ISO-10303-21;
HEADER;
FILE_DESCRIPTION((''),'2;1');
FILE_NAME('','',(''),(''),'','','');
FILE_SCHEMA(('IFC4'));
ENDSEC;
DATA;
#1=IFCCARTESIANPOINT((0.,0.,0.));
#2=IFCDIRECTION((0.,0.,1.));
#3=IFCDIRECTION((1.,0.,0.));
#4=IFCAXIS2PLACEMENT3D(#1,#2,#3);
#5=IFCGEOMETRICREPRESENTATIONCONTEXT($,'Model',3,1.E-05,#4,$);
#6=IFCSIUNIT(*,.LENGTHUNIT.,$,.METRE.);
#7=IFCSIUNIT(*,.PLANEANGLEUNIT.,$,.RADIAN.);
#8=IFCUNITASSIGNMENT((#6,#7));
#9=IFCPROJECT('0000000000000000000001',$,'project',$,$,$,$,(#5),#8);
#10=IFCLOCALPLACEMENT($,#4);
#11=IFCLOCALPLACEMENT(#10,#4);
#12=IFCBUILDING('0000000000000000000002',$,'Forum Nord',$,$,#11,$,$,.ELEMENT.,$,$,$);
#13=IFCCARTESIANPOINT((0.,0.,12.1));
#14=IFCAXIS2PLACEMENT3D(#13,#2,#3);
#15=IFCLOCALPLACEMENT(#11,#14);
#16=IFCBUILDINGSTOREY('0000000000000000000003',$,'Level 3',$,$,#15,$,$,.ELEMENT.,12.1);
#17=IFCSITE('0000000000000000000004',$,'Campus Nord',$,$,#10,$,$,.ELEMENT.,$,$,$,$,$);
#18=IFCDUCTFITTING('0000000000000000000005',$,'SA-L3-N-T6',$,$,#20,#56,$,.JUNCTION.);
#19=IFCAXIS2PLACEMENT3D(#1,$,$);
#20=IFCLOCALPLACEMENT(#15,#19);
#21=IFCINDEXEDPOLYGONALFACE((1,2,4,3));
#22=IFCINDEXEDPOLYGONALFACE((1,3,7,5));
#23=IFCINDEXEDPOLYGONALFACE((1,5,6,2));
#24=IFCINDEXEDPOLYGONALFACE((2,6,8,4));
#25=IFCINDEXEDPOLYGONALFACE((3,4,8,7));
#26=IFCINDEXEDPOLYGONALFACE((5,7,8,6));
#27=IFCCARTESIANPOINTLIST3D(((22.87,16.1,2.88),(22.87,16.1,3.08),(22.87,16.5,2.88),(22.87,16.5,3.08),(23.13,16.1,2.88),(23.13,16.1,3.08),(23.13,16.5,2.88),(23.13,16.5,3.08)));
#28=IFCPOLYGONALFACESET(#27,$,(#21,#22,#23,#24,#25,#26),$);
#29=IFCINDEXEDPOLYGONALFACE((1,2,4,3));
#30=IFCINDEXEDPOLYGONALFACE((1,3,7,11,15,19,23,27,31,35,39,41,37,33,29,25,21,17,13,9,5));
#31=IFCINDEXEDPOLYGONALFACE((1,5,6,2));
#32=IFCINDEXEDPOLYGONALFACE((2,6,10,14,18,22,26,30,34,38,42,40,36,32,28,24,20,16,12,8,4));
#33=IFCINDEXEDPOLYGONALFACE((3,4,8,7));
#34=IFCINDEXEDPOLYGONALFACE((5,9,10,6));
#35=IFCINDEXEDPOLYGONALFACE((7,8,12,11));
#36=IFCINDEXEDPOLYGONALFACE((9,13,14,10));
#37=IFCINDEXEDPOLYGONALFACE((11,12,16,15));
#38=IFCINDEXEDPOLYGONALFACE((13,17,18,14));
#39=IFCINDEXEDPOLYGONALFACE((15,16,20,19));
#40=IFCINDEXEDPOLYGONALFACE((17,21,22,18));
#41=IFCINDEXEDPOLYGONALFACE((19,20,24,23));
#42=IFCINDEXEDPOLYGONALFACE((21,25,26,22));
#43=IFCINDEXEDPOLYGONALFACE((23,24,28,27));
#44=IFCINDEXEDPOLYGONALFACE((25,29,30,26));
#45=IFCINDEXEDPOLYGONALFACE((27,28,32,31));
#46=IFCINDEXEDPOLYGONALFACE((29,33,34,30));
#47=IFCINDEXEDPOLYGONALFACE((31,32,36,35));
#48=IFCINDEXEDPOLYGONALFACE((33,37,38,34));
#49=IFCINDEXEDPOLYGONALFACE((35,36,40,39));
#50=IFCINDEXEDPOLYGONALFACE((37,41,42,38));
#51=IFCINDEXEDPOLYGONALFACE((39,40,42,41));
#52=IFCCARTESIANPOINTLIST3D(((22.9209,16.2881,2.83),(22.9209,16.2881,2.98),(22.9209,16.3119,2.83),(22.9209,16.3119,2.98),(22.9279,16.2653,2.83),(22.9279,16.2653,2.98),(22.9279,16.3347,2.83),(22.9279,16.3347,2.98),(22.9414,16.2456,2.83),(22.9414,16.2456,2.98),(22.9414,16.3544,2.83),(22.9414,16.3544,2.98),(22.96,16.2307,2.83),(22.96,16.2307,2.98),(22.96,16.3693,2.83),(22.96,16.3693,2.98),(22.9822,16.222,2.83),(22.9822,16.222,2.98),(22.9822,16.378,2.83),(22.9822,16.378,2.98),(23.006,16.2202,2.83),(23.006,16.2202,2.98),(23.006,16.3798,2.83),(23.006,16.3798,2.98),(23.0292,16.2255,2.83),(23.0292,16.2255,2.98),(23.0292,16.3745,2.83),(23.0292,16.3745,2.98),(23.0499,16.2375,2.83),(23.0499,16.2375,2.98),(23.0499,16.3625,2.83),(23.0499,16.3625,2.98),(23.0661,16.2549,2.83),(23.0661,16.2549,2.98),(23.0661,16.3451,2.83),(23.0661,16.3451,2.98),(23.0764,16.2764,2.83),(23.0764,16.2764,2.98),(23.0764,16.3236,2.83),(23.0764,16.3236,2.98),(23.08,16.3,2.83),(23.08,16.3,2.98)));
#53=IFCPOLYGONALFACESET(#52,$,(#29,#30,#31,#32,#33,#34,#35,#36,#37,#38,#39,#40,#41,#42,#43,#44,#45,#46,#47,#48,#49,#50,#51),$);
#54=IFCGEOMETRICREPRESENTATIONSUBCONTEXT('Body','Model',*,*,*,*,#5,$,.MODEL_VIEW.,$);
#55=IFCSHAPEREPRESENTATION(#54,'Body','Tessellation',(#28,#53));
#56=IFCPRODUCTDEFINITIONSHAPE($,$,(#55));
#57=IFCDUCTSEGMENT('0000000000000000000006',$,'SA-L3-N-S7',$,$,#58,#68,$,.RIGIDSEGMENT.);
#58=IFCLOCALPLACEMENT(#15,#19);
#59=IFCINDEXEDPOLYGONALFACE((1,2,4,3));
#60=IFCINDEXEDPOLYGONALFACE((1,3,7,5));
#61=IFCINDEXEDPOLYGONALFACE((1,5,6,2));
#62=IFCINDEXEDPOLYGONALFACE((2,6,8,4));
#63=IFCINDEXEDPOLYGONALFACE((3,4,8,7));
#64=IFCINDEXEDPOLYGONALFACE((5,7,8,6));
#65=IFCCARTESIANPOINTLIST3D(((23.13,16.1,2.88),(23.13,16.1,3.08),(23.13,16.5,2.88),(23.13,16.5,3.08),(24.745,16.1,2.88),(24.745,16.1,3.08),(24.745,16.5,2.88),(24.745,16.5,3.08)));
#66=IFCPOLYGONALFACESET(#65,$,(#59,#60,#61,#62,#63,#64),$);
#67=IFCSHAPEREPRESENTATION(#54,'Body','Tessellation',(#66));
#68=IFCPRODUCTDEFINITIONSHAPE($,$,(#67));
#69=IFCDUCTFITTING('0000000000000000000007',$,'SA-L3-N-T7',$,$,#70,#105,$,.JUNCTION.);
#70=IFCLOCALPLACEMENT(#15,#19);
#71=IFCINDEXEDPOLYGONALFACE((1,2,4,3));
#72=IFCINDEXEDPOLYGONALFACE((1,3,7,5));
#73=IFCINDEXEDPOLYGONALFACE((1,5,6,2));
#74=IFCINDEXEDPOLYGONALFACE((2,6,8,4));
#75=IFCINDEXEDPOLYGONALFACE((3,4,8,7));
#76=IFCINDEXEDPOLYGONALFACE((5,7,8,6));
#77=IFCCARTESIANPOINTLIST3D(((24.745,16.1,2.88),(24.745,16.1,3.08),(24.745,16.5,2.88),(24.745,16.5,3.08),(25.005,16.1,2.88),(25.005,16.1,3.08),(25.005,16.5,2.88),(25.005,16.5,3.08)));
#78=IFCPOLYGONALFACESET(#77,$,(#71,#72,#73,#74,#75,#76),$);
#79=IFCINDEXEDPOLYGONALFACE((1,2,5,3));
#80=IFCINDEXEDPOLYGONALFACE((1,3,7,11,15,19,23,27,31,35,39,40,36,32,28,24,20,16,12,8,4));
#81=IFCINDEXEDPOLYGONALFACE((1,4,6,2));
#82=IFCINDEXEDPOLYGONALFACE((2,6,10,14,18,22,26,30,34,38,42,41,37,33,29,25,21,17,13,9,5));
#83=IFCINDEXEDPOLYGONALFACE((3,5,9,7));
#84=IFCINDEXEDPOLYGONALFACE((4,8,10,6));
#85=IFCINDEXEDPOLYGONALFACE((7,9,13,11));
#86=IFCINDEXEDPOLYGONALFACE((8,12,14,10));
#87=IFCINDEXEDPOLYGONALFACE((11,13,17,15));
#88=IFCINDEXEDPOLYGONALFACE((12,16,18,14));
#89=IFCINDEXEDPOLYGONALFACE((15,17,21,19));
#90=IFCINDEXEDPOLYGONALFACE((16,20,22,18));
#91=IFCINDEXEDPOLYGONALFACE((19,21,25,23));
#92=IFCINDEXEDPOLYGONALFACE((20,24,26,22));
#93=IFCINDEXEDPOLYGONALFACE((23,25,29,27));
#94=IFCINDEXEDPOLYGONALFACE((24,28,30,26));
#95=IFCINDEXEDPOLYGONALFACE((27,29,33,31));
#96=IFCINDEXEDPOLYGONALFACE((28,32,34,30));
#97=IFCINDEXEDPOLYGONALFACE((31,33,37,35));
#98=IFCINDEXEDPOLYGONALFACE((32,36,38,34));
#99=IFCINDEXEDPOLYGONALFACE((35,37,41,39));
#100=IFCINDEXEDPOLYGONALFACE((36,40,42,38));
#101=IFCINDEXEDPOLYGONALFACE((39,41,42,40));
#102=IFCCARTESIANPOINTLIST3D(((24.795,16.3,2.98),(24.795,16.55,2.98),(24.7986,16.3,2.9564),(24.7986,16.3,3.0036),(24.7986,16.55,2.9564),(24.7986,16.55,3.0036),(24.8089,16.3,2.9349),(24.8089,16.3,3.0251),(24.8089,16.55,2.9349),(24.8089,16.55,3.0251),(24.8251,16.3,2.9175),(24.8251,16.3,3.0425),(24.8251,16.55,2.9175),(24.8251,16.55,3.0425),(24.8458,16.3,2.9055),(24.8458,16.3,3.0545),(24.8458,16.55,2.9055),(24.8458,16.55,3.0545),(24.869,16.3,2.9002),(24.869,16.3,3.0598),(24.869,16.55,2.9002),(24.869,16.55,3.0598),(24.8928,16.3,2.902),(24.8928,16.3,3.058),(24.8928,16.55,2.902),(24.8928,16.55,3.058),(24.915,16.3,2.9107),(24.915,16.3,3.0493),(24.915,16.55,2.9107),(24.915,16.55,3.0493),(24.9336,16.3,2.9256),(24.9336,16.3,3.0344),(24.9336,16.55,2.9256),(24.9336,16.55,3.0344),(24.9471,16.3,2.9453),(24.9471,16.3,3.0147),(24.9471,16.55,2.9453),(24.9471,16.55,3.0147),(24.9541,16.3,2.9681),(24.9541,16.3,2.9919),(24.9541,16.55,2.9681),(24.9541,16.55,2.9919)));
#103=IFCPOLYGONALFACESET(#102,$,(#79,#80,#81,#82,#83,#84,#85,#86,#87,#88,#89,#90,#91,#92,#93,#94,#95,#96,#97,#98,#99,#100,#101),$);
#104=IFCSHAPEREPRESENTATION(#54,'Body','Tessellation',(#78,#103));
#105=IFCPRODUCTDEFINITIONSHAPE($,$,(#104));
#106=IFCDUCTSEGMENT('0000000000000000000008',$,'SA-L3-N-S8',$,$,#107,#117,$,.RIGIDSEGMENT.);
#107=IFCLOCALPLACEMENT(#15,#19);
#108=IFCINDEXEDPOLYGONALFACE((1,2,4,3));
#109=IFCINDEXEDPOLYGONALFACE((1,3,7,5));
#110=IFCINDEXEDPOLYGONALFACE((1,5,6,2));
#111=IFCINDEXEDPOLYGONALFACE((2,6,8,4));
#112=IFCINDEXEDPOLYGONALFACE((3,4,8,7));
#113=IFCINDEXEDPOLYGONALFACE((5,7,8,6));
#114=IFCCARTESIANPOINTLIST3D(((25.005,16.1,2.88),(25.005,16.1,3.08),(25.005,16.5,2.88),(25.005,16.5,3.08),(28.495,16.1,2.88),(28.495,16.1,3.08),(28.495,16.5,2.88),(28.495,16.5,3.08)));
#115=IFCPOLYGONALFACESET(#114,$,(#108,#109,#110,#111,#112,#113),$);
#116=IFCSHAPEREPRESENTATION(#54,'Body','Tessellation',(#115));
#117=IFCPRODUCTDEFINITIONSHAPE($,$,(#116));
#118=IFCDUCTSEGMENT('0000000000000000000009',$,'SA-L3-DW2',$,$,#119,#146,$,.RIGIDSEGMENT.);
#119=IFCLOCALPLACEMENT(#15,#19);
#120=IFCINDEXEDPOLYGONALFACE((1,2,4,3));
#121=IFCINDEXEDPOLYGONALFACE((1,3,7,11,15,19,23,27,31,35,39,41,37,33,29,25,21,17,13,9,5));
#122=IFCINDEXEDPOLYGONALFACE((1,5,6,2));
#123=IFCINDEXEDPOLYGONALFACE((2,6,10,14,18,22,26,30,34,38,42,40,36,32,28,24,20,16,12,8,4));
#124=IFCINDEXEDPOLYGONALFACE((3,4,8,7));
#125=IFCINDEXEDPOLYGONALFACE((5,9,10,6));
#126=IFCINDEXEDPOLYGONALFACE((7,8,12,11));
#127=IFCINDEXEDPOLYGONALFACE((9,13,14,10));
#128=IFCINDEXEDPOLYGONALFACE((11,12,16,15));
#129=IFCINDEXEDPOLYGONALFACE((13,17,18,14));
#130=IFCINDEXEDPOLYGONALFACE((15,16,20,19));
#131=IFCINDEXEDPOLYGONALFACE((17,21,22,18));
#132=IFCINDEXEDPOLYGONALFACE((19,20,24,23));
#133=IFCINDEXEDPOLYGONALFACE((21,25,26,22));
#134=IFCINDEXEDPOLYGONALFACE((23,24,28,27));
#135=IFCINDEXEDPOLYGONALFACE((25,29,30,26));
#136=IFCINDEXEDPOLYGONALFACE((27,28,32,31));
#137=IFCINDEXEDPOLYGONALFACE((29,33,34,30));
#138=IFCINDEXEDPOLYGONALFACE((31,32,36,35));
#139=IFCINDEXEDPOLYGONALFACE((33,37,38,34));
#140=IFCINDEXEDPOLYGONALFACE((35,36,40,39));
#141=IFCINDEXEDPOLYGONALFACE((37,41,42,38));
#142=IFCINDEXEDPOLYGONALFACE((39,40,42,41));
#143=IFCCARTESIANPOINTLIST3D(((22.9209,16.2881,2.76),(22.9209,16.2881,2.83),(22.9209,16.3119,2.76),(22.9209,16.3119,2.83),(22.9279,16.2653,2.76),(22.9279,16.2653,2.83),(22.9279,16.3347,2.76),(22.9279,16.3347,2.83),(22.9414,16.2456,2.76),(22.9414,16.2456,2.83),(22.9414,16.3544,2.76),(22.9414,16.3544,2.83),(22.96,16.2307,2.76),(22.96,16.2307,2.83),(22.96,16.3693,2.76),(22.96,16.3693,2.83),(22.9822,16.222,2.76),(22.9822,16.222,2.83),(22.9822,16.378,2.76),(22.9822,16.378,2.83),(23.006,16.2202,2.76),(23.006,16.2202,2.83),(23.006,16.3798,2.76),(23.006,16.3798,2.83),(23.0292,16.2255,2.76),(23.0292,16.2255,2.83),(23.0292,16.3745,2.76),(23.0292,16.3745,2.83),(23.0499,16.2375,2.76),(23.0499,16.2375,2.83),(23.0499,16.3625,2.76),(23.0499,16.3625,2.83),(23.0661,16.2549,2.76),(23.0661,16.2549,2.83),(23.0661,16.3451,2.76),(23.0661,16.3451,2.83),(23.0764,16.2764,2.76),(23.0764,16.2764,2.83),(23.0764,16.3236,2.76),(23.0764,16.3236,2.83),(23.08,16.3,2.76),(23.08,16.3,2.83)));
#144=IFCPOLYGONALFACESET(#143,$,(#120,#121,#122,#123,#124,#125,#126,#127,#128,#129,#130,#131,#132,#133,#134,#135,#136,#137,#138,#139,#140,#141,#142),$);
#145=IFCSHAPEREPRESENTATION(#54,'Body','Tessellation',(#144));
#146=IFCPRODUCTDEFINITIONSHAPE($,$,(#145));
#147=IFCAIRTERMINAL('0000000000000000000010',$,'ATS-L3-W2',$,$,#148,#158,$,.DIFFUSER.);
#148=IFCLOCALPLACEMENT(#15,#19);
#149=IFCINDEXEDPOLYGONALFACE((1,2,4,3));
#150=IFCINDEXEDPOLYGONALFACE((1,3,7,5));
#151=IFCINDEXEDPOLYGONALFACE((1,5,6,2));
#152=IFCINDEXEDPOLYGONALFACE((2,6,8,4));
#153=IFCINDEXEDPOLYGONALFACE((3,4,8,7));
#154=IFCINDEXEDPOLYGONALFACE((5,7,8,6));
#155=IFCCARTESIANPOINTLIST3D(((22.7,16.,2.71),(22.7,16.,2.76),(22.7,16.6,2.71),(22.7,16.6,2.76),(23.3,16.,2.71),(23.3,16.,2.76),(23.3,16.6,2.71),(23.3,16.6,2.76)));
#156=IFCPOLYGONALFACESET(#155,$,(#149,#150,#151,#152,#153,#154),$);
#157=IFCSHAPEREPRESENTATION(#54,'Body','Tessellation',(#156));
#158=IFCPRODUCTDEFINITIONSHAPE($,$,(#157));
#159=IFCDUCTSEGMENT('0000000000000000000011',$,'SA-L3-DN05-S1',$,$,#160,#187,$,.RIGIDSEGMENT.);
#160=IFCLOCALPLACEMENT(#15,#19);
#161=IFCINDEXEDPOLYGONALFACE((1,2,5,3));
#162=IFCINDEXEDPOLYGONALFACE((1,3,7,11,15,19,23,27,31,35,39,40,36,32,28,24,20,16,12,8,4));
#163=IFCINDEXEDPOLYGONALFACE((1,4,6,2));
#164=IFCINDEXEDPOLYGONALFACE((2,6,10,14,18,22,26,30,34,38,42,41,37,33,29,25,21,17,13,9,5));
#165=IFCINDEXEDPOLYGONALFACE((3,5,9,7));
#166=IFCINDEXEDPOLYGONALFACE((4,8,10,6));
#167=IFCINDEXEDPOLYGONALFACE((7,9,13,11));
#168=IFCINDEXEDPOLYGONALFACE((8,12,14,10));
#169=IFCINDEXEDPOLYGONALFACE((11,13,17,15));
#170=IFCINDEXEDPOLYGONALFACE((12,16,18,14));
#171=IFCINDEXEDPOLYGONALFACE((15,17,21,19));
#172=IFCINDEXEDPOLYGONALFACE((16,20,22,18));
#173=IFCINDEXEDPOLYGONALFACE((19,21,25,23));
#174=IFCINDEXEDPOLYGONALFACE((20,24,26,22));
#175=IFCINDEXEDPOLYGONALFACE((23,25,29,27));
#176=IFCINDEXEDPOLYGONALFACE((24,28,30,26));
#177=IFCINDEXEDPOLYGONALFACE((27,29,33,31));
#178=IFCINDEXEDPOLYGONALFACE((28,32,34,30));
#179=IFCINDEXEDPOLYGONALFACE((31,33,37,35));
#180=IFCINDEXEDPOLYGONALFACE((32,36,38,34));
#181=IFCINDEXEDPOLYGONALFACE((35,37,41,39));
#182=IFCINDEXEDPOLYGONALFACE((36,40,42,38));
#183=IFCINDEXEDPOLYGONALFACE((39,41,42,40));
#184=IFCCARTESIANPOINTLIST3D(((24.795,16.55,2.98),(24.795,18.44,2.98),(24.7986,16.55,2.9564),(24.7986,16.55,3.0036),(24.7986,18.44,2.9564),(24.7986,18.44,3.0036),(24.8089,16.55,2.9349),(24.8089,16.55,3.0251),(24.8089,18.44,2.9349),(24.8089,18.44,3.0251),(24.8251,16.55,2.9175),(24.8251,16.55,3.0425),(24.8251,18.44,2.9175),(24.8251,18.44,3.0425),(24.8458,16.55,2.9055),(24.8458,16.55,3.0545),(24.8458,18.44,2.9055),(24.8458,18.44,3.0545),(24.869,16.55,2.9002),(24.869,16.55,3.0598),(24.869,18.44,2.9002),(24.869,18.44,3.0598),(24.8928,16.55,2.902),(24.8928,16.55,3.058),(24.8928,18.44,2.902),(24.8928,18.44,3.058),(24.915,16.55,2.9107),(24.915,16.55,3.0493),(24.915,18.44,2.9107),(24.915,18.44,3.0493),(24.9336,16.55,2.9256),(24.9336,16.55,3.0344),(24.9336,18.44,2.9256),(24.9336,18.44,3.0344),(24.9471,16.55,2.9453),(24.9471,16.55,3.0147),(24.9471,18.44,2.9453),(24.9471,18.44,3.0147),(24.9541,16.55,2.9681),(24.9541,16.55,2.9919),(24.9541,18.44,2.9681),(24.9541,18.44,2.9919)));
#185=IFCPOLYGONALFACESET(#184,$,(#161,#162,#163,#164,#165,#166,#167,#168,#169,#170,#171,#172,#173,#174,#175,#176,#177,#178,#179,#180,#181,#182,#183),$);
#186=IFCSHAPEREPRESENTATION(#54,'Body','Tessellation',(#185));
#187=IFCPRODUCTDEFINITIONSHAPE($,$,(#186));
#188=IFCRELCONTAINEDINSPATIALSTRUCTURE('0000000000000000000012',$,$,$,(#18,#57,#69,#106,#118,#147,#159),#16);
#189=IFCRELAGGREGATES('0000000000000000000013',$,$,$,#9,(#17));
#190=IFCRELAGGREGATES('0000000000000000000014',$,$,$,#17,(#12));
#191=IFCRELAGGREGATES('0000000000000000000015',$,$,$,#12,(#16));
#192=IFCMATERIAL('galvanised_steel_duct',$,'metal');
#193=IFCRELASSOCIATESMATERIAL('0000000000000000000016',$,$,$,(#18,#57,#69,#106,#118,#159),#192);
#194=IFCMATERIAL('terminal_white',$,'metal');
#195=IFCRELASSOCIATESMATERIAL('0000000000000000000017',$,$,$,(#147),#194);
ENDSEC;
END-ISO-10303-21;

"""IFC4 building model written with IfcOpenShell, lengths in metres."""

from ifc_helpers import new_model, si_unit, frame, origin_with_axes, origin_2d_with_axis, place, context, subcontext, project, spatial, rectangle, circle, extrude, material, element, save


model = new_model("IFC4")

# Units and contexts
model_context = context("Model", 3, precision=1e-05, world=origin_with_axes())
body_context = subcontext(model_context, "Body", "Model", "MODEL_VIEW")
ifc_project = project(units=[si_unit("LENGTHUNIT", "METRE"), si_unit("PLANEANGLEUNIT", "RADIAN")], contexts=[model_context])

# Site, building, storey
site_placement = place(None, origin_with_axes())
site = spatial("IfcSite", under=ifc_project, at=site_placement, Name="Campus Nord", CompositionType="ELEMENT")
building_placement = place(site_placement, origin_with_axes())
building = spatial("IfcBuilding", under=site, at=building_placement, Name="Forum Nord", CompositionType="ELEMENT")
storey_placement = place(building_placement, frame((0.0, 0.0, 12.1), z_axis=(0.0, 0.0, 1.0), x_axis=(1.0, 0.0, 0.0)))
storey = spatial("IfcBuildingStorey", under=building, at=storey_placement, Name="Level 3", CompositionType="ELEMENT", Elevation=12.1)

# Duct fitting
ifc_material_1 = material(Name="galvanised_steel_duct", Category="metal")
duct_fitting_1_placement = place(storey_placement, frame((22.87, 16.3, 2.98), z_axis=(1.0, 0.0, 0.0), x_axis=(0.0, 1.0, 0.0)))
element("IfcDuctFitting", 1, at=duct_fitting_1_placement, inside=storey, material=ifc_material_1, Name="SA-L3-N-T6", PredefinedType="JUNCTION", context=body_context, shape_type="SweptSolid", body=[
    extrude(rectangle(XDim=0.4, YDim=0.2, at=origin_2d_with_axis()), origin_with_axes(), (0.0, 0.0, 1.0), 0.26),
    extrude(circle(Radius=0.08, at=origin_2d_with_axis()), frame((0.0, 0.0, 0.13), z_axis=(0.0, -1.0, 0.0), x_axis=(0.0, 0.0, 1.0)), (0.0, 0.0, 1.0), 0.15),
])

# Duct segment
duct_segment_1_placement = place(storey_placement, frame((23.13, 16.3, 2.98), z_axis=(1.0, 0.0, 0.0), x_axis=(0.0, 1.0, 0.0)))
element("IfcDuctSegment", 2, at=duct_segment_1_placement, inside=storey, material=ifc_material_1, Name="SA-L3-N-S7", PredefinedType="RIGIDSEGMENT", context=body_context, shape_type="SweptSolid", body=[
    extrude(rectangle(XDim=0.4, YDim=0.2, at=origin_2d_with_axis()), origin_with_axes(), (0.0, 0.0, 1.0), 1.615),
])

# Duct fitting
duct_fitting_2_placement = place(storey_placement, frame((24.745, 16.3, 2.98), z_axis=(1.0, 0.0, 0.0), x_axis=(0.0, 1.0, 0.0)))
element("IfcDuctFitting", 3, at=duct_fitting_2_placement, inside=storey, material=ifc_material_1, Name="SA-L3-N-T7", PredefinedType="JUNCTION", context=body_context, shape_type="SweptSolid", body=[
    extrude(rectangle(XDim=0.4, YDim=0.2, at=origin_2d_with_axis()), origin_with_axes(), (0.0, 0.0, 1.0), 0.26),
    extrude(circle(Radius=0.08, at=origin_2d_with_axis()), frame((0.0, 0.0, 0.13), z_axis=(1.0, 0.0, 0.0), x_axis=(0.0, 0.0, -1.0)), (0.0, 0.0, 1.0), 0.25),
])

# Duct segments
duct_segment_2_placement = place(storey_placement, frame((25.005, 16.3, 2.98), z_axis=(1.0, 0.0, 0.0), x_axis=(0.0, 1.0, 0.0)))
element("IfcDuctSegment", 4, at=duct_segment_2_placement, inside=storey, material=ifc_material_1, Name="SA-L3-N-S8", PredefinedType="RIGIDSEGMENT", context=body_context, shape_type="SweptSolid", body=[
    extrude(rectangle(XDim=0.4, YDim=0.2, at=origin_2d_with_axis()), origin_with_axes(), (0.0, 0.0, 1.0), 3.49),
])
duct_segment_3_placement = place(storey_placement, frame((23.0, 16.3, 2.83), z_axis=(0.0, 0.0, -1.0), x_axis=(1.0, 0.0, 0.0)))
element("IfcDuctSegment", 5, at=duct_segment_3_placement, inside=storey, material=ifc_material_1, Name="SA-L3-DW2", PredefinedType="RIGIDSEGMENT", context=body_context, shape_type="SweptSolid", body=[
    extrude(circle(Radius=0.08, at=origin_2d_with_axis()), origin_with_axes(), (0.0, 0.0, 1.0), 0.07),
])

# Air terminal
ifc_material_2 = material(Name="terminal_white", Category="metal")
air_terminal_1_placement = place(storey_placement, frame((23.0, 16.3, 2.71), z_axis=(0.0, 0.0, 1.0), x_axis=(1.0, 0.0, 0.0)))
element("IfcAirTerminal", 6, at=air_terminal_1_placement, inside=storey, material=ifc_material_2, Name="ATS-L3-W2", PredefinedType="DIFFUSER", context=body_context, shape_type="SweptSolid", body=[
    extrude(rectangle(XDim=0.6, YDim=0.6, at=origin_2d_with_axis()), origin_with_axes(), (0.0, 0.0, 1.0), 0.05),
])

# Duct segment
duct_segment_4_placement = place(storey_placement, frame((24.875, 16.55, 2.98), z_axis=(0.0, 1.0, 0.0), x_axis=(-1.0, 0.0, 0.0)))
element("IfcDuctSegment", 7, at=duct_segment_4_placement, inside=storey, material=ifc_material_1, Name="SA-L3-DN05-S1", PredefinedType="RIGIDSEGMENT", context=body_context, shape_type="SweptSolid", body=[
    extrude(circle(Radius=0.08, at=origin_2d_with_axis()), origin_with_axes(), (0.0, 0.0, 1.0), 1.89),
])

save(model, "model.ifc")
